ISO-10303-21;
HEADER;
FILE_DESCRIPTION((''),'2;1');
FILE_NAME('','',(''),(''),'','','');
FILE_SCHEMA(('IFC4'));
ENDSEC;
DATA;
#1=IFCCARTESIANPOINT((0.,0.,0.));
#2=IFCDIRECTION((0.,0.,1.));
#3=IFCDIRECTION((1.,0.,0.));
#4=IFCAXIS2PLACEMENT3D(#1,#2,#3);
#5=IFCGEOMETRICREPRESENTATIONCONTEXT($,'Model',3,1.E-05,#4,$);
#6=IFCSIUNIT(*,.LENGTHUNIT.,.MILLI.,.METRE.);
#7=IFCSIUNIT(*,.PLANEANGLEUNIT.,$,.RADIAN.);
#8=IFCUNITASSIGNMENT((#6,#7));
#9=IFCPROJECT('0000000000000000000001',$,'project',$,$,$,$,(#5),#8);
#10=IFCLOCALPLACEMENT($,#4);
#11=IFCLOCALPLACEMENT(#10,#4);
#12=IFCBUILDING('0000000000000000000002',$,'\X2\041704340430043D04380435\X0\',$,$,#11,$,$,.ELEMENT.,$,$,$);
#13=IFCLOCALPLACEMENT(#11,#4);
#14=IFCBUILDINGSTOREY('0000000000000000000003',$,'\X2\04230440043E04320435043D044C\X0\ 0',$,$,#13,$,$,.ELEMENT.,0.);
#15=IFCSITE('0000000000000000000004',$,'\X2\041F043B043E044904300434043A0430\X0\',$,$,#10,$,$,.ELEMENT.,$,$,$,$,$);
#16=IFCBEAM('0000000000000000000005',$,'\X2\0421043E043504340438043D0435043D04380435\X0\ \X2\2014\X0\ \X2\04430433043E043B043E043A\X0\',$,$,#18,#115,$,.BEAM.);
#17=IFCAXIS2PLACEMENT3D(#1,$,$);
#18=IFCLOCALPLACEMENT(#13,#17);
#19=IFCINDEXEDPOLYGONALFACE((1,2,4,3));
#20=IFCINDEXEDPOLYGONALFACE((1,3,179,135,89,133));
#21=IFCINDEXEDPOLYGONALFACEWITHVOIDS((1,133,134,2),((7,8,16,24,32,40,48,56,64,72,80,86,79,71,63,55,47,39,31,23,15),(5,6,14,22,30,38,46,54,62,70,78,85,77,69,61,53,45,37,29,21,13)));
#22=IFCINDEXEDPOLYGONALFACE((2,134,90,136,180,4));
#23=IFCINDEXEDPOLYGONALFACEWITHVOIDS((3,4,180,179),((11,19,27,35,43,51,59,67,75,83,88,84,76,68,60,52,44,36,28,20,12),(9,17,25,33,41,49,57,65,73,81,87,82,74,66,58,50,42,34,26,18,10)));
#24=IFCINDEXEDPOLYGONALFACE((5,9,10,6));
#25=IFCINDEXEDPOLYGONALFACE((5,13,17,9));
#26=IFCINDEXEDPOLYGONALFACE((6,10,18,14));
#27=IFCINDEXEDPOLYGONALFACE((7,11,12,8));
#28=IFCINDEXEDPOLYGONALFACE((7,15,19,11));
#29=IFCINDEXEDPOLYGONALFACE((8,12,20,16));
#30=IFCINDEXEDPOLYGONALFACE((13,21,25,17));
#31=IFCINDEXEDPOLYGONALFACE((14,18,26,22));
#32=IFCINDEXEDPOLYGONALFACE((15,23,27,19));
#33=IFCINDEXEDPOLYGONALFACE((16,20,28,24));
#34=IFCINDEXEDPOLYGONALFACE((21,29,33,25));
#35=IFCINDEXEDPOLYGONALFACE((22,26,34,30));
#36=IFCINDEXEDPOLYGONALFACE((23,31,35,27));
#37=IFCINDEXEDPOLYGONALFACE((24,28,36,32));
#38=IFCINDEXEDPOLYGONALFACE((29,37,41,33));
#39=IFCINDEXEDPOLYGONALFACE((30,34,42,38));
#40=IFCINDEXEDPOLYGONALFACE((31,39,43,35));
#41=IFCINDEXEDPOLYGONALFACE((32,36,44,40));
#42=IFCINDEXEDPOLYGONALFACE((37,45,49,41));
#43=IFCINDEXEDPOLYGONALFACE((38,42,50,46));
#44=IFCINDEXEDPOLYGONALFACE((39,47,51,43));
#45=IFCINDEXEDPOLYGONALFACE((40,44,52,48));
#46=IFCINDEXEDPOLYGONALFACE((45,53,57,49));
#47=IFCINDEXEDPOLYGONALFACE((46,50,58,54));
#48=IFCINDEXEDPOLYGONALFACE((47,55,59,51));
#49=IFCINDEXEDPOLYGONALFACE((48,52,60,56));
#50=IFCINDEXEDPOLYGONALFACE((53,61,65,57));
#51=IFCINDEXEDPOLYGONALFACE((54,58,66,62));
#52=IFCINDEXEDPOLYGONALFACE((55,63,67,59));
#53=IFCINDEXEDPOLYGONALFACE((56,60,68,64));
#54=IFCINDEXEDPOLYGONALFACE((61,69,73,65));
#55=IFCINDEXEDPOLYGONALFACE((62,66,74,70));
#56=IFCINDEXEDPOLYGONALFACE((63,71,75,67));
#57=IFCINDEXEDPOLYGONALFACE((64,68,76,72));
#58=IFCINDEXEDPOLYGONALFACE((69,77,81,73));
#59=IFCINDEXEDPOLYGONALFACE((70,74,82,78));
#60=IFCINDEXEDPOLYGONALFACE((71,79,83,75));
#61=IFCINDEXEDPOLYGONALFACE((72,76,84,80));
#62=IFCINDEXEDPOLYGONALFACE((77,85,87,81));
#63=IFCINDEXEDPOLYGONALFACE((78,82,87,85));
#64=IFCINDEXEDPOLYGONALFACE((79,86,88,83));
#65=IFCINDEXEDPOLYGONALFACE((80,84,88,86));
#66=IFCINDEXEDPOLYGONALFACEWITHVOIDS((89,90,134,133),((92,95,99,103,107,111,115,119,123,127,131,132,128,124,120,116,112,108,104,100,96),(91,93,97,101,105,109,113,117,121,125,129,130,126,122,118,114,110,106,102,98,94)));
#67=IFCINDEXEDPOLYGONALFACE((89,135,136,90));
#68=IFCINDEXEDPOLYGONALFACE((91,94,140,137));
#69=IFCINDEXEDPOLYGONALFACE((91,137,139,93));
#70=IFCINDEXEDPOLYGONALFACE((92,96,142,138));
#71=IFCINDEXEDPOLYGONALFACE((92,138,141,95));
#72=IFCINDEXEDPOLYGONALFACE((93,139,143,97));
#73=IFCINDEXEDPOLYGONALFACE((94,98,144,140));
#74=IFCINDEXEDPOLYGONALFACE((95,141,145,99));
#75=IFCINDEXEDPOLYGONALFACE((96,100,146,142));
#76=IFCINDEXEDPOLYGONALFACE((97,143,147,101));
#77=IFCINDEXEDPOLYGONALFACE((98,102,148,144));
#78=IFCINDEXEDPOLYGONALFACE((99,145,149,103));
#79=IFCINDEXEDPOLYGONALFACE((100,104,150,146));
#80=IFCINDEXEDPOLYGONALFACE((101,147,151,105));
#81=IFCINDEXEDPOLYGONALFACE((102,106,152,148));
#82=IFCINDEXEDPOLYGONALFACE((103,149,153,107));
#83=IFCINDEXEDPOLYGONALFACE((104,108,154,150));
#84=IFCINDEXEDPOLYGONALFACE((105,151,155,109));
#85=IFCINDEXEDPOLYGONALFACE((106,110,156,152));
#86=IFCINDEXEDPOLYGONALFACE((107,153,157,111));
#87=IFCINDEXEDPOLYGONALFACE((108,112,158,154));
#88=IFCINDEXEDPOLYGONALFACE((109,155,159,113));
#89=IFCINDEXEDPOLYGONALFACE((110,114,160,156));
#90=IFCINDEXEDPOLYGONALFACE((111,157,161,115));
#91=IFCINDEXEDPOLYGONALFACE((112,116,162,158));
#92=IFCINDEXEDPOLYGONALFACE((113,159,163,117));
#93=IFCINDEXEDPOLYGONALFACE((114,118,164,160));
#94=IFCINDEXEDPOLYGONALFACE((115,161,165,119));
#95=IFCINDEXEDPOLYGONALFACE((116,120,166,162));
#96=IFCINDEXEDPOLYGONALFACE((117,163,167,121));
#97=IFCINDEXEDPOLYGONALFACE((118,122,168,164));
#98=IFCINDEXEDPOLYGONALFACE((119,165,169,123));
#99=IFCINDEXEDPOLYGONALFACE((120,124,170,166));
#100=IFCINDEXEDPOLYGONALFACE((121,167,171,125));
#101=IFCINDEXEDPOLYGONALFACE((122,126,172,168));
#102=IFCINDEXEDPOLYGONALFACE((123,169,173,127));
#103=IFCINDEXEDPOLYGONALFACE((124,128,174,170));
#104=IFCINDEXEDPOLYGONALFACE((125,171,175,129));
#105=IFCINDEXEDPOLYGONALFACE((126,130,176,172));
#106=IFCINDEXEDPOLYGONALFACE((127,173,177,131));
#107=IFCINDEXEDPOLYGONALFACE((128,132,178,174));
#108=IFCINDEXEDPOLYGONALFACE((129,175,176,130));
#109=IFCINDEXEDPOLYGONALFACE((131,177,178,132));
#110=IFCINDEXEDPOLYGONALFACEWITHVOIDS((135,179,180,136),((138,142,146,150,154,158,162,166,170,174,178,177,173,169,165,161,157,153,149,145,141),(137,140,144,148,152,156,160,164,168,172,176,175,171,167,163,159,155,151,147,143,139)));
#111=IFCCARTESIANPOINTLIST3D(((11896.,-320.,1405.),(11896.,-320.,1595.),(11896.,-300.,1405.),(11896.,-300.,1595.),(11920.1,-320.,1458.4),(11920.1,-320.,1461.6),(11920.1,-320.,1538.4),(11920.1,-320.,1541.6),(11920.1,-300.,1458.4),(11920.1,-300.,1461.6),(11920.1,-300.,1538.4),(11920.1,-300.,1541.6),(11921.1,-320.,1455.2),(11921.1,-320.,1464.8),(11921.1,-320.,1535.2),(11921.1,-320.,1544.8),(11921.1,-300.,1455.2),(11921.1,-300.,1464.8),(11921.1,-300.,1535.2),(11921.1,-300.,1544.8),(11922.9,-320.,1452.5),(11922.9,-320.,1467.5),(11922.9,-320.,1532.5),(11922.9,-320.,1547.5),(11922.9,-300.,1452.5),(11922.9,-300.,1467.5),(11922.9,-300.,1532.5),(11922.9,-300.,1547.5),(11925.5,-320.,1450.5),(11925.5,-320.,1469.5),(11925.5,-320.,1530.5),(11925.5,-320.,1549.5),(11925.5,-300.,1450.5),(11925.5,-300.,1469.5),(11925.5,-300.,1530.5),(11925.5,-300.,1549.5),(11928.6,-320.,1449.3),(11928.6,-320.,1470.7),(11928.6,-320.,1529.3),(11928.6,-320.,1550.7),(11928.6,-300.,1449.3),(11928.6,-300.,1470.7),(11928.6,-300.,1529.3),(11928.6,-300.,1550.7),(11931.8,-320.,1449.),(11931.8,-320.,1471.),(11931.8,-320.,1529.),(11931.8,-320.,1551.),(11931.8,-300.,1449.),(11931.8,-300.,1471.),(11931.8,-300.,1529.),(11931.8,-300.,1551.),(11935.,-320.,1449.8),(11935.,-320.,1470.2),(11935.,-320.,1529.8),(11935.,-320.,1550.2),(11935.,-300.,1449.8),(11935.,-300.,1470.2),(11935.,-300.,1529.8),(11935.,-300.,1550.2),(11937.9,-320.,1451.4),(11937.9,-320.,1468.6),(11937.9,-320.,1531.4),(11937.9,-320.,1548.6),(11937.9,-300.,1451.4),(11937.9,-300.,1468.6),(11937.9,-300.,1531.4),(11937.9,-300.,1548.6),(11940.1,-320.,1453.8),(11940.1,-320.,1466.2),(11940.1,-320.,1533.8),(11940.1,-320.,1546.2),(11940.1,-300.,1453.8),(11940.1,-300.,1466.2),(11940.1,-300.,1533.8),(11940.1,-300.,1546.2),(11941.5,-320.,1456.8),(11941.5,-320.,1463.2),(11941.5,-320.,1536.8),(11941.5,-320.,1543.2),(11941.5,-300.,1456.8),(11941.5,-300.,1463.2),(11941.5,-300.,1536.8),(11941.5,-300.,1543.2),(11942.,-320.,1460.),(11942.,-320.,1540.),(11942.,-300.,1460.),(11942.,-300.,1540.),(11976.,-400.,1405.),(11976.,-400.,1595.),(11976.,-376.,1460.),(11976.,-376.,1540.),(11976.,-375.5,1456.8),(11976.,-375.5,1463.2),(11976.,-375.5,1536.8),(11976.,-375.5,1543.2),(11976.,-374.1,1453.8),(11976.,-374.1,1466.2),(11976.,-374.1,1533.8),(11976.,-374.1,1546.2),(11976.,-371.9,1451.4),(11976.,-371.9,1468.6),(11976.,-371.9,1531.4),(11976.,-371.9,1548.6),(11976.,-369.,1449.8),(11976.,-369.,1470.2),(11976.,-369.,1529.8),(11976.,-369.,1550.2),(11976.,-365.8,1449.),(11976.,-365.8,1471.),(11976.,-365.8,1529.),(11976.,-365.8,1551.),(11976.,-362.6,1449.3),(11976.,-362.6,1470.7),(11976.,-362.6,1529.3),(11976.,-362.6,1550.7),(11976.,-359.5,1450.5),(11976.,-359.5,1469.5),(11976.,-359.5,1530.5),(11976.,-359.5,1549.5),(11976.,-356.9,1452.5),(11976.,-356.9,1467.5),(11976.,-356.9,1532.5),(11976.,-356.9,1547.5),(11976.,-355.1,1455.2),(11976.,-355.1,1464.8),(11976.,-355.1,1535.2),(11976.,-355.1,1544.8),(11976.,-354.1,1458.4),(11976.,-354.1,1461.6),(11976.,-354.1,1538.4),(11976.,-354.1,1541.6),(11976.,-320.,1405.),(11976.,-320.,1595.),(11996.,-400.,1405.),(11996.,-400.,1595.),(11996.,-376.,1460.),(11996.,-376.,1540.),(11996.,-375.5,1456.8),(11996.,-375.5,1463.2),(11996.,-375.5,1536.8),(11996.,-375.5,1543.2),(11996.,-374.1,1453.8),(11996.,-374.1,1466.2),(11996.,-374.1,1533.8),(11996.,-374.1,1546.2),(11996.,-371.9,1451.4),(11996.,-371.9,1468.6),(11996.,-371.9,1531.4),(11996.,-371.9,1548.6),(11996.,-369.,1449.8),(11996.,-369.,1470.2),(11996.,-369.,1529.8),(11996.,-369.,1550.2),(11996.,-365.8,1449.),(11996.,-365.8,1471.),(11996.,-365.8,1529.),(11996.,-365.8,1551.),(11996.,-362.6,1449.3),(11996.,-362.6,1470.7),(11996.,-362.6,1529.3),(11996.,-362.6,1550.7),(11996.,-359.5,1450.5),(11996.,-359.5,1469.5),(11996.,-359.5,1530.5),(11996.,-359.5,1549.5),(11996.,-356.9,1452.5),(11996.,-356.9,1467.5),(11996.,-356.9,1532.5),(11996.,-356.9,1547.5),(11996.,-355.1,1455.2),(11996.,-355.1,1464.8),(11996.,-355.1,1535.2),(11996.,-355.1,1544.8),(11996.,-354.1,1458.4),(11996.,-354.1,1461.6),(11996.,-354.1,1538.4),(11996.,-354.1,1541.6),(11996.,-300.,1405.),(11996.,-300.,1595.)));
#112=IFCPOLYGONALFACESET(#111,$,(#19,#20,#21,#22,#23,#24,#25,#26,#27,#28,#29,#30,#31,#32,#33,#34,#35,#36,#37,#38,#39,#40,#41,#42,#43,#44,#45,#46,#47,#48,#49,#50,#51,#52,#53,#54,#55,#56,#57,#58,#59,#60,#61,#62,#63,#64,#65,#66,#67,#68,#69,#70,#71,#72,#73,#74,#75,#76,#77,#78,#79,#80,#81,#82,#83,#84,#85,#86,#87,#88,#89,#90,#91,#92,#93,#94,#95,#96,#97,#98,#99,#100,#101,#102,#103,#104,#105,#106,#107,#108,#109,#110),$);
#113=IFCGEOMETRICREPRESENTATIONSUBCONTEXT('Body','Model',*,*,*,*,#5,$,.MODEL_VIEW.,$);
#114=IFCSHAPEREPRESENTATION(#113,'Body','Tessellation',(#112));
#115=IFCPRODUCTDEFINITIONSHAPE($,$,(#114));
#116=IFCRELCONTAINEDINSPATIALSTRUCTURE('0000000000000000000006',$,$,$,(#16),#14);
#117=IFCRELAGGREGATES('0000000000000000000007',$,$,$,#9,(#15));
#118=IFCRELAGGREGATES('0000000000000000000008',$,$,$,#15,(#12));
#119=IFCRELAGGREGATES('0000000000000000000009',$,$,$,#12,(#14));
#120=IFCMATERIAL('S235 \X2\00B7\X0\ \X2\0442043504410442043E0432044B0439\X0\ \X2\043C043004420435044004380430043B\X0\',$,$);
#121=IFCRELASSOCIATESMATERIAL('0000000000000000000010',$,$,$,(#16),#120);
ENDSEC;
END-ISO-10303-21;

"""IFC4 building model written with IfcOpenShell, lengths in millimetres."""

from ifc_helpers import new_model, si_unit, frame, origin_with_axes, place, context, subcontext, project, spatial, circle, l_section, extrude, material, element, save


model = new_model("IFC4")

# Units and contexts
model_context = context("Model", 3, precision=1e-05, world=origin_with_axes())
body_context = subcontext(model_context, "Body", "Model", "MODEL_VIEW")
ifc_project = project(units=[si_unit("LENGTHUNIT", "METRE", prefix="MILLI"), si_unit("PLANEANGLEUNIT", "RADIAN")], contexts=[model_context])

# Site, building, storey
site_placement = place(None, origin_with_axes())
site = spatial("IfcSite", under=ifc_project, at=site_placement, Name="Площадка", CompositionType="ELEMENT")
building_placement = place(site_placement, origin_with_axes())
building = spatial("IfcBuilding", under=site, at=building_placement, Name="Здание", CompositionType="ELEMENT")
storey_placement = place(building_placement, origin_with_axes())
storey = spatial("IfcBuildingStorey", under=building, at=storey_placement, Name="Уровень 0", CompositionType="ELEMENT", Elevation=0.0)

# Shared definitions
ifc_material = material(Name="S235 · тестовый материал")

# Beam, openings
beam_1_placement = place(storey_placement, frame((11946.0, -350.0, 1595.0), z_axis=(0.0, 0.0, -1.0), x_axis=(0.0, -1.0, 0.0)))
beam_1 = element("IfcBeam", 1, at=beam_1_placement, inside=storey, material=ifc_material, Name="Соединение — уголок", PredefinedType="BEAM", context=body_context, shape_type="SweptSolid", body=[
    extrude(l_section(Depth=100.0, Width=100.0, Thickness=20.0), origin_with_axes(), (0.0, 0.0, 1.0), 190.0),
])
opening_1_placement = place(beam_1_placement, frame((15.0, -29.0, 55.0), z_axis=(0.0, -1.0, 0.0), x_axis=(1.0, 0.0, 0.0)))
element("IfcOpeningElement", 2, at=opening_1_placement, cuts=beam_1, PredefinedType="OPENING", context=body_context, shape_type="SweptSolid", body=[
    extrude(circle(Radius=11.0), origin_with_axes(), (0.0, 0.0, 1.0), 30.0),
])
opening_2_placement = place(beam_1_placement, frame((15.0, -29.0, 135.0), z_axis=(0.0, -1.0, 0.0), x_axis=(1.0, 0.0, 0.0)))
element("IfcOpeningElement", 3, at=opening_2_placement, cuts=beam_1, PredefinedType="OPENING", context=body_context, shape_type="SweptSolid", body=[
    extrude(circle(Radius=11.0), origin_with_axes(), (0.0, 0.0, 1.0), 30.0),
])
opening_3_placement = place(beam_1_placement, frame((-29.0, 15.0, 55.0), z_axis=(-1.0, 0.0, 0.0), x_axis=(0.0, -1.0, 0.0)))
element("IfcOpeningElement", 4, at=opening_3_placement, cuts=beam_1, PredefinedType="OPENING", context=body_context, shape_type="SweptSolid", body=[
    extrude(circle(Radius=11.0), origin_with_axes(), (0.0, 0.0, 1.0), 42.0),
])
opening_4_placement = place(beam_1_placement, frame((-29.0, 15.0, 135.0), z_axis=(-1.0, 0.0, 0.0), x_axis=(0.0, -1.0, 0.0)))
element("IfcOpeningElement", 5, at=opening_4_placement, cuts=beam_1, PredefinedType="OPENING", context=body_context, shape_type="SweptSolid", body=[
    extrude(circle(Radius=11.0), origin_with_axes(), (0.0, 0.0, 1.0), 42.0),
])

save(model, "model.ifc")
